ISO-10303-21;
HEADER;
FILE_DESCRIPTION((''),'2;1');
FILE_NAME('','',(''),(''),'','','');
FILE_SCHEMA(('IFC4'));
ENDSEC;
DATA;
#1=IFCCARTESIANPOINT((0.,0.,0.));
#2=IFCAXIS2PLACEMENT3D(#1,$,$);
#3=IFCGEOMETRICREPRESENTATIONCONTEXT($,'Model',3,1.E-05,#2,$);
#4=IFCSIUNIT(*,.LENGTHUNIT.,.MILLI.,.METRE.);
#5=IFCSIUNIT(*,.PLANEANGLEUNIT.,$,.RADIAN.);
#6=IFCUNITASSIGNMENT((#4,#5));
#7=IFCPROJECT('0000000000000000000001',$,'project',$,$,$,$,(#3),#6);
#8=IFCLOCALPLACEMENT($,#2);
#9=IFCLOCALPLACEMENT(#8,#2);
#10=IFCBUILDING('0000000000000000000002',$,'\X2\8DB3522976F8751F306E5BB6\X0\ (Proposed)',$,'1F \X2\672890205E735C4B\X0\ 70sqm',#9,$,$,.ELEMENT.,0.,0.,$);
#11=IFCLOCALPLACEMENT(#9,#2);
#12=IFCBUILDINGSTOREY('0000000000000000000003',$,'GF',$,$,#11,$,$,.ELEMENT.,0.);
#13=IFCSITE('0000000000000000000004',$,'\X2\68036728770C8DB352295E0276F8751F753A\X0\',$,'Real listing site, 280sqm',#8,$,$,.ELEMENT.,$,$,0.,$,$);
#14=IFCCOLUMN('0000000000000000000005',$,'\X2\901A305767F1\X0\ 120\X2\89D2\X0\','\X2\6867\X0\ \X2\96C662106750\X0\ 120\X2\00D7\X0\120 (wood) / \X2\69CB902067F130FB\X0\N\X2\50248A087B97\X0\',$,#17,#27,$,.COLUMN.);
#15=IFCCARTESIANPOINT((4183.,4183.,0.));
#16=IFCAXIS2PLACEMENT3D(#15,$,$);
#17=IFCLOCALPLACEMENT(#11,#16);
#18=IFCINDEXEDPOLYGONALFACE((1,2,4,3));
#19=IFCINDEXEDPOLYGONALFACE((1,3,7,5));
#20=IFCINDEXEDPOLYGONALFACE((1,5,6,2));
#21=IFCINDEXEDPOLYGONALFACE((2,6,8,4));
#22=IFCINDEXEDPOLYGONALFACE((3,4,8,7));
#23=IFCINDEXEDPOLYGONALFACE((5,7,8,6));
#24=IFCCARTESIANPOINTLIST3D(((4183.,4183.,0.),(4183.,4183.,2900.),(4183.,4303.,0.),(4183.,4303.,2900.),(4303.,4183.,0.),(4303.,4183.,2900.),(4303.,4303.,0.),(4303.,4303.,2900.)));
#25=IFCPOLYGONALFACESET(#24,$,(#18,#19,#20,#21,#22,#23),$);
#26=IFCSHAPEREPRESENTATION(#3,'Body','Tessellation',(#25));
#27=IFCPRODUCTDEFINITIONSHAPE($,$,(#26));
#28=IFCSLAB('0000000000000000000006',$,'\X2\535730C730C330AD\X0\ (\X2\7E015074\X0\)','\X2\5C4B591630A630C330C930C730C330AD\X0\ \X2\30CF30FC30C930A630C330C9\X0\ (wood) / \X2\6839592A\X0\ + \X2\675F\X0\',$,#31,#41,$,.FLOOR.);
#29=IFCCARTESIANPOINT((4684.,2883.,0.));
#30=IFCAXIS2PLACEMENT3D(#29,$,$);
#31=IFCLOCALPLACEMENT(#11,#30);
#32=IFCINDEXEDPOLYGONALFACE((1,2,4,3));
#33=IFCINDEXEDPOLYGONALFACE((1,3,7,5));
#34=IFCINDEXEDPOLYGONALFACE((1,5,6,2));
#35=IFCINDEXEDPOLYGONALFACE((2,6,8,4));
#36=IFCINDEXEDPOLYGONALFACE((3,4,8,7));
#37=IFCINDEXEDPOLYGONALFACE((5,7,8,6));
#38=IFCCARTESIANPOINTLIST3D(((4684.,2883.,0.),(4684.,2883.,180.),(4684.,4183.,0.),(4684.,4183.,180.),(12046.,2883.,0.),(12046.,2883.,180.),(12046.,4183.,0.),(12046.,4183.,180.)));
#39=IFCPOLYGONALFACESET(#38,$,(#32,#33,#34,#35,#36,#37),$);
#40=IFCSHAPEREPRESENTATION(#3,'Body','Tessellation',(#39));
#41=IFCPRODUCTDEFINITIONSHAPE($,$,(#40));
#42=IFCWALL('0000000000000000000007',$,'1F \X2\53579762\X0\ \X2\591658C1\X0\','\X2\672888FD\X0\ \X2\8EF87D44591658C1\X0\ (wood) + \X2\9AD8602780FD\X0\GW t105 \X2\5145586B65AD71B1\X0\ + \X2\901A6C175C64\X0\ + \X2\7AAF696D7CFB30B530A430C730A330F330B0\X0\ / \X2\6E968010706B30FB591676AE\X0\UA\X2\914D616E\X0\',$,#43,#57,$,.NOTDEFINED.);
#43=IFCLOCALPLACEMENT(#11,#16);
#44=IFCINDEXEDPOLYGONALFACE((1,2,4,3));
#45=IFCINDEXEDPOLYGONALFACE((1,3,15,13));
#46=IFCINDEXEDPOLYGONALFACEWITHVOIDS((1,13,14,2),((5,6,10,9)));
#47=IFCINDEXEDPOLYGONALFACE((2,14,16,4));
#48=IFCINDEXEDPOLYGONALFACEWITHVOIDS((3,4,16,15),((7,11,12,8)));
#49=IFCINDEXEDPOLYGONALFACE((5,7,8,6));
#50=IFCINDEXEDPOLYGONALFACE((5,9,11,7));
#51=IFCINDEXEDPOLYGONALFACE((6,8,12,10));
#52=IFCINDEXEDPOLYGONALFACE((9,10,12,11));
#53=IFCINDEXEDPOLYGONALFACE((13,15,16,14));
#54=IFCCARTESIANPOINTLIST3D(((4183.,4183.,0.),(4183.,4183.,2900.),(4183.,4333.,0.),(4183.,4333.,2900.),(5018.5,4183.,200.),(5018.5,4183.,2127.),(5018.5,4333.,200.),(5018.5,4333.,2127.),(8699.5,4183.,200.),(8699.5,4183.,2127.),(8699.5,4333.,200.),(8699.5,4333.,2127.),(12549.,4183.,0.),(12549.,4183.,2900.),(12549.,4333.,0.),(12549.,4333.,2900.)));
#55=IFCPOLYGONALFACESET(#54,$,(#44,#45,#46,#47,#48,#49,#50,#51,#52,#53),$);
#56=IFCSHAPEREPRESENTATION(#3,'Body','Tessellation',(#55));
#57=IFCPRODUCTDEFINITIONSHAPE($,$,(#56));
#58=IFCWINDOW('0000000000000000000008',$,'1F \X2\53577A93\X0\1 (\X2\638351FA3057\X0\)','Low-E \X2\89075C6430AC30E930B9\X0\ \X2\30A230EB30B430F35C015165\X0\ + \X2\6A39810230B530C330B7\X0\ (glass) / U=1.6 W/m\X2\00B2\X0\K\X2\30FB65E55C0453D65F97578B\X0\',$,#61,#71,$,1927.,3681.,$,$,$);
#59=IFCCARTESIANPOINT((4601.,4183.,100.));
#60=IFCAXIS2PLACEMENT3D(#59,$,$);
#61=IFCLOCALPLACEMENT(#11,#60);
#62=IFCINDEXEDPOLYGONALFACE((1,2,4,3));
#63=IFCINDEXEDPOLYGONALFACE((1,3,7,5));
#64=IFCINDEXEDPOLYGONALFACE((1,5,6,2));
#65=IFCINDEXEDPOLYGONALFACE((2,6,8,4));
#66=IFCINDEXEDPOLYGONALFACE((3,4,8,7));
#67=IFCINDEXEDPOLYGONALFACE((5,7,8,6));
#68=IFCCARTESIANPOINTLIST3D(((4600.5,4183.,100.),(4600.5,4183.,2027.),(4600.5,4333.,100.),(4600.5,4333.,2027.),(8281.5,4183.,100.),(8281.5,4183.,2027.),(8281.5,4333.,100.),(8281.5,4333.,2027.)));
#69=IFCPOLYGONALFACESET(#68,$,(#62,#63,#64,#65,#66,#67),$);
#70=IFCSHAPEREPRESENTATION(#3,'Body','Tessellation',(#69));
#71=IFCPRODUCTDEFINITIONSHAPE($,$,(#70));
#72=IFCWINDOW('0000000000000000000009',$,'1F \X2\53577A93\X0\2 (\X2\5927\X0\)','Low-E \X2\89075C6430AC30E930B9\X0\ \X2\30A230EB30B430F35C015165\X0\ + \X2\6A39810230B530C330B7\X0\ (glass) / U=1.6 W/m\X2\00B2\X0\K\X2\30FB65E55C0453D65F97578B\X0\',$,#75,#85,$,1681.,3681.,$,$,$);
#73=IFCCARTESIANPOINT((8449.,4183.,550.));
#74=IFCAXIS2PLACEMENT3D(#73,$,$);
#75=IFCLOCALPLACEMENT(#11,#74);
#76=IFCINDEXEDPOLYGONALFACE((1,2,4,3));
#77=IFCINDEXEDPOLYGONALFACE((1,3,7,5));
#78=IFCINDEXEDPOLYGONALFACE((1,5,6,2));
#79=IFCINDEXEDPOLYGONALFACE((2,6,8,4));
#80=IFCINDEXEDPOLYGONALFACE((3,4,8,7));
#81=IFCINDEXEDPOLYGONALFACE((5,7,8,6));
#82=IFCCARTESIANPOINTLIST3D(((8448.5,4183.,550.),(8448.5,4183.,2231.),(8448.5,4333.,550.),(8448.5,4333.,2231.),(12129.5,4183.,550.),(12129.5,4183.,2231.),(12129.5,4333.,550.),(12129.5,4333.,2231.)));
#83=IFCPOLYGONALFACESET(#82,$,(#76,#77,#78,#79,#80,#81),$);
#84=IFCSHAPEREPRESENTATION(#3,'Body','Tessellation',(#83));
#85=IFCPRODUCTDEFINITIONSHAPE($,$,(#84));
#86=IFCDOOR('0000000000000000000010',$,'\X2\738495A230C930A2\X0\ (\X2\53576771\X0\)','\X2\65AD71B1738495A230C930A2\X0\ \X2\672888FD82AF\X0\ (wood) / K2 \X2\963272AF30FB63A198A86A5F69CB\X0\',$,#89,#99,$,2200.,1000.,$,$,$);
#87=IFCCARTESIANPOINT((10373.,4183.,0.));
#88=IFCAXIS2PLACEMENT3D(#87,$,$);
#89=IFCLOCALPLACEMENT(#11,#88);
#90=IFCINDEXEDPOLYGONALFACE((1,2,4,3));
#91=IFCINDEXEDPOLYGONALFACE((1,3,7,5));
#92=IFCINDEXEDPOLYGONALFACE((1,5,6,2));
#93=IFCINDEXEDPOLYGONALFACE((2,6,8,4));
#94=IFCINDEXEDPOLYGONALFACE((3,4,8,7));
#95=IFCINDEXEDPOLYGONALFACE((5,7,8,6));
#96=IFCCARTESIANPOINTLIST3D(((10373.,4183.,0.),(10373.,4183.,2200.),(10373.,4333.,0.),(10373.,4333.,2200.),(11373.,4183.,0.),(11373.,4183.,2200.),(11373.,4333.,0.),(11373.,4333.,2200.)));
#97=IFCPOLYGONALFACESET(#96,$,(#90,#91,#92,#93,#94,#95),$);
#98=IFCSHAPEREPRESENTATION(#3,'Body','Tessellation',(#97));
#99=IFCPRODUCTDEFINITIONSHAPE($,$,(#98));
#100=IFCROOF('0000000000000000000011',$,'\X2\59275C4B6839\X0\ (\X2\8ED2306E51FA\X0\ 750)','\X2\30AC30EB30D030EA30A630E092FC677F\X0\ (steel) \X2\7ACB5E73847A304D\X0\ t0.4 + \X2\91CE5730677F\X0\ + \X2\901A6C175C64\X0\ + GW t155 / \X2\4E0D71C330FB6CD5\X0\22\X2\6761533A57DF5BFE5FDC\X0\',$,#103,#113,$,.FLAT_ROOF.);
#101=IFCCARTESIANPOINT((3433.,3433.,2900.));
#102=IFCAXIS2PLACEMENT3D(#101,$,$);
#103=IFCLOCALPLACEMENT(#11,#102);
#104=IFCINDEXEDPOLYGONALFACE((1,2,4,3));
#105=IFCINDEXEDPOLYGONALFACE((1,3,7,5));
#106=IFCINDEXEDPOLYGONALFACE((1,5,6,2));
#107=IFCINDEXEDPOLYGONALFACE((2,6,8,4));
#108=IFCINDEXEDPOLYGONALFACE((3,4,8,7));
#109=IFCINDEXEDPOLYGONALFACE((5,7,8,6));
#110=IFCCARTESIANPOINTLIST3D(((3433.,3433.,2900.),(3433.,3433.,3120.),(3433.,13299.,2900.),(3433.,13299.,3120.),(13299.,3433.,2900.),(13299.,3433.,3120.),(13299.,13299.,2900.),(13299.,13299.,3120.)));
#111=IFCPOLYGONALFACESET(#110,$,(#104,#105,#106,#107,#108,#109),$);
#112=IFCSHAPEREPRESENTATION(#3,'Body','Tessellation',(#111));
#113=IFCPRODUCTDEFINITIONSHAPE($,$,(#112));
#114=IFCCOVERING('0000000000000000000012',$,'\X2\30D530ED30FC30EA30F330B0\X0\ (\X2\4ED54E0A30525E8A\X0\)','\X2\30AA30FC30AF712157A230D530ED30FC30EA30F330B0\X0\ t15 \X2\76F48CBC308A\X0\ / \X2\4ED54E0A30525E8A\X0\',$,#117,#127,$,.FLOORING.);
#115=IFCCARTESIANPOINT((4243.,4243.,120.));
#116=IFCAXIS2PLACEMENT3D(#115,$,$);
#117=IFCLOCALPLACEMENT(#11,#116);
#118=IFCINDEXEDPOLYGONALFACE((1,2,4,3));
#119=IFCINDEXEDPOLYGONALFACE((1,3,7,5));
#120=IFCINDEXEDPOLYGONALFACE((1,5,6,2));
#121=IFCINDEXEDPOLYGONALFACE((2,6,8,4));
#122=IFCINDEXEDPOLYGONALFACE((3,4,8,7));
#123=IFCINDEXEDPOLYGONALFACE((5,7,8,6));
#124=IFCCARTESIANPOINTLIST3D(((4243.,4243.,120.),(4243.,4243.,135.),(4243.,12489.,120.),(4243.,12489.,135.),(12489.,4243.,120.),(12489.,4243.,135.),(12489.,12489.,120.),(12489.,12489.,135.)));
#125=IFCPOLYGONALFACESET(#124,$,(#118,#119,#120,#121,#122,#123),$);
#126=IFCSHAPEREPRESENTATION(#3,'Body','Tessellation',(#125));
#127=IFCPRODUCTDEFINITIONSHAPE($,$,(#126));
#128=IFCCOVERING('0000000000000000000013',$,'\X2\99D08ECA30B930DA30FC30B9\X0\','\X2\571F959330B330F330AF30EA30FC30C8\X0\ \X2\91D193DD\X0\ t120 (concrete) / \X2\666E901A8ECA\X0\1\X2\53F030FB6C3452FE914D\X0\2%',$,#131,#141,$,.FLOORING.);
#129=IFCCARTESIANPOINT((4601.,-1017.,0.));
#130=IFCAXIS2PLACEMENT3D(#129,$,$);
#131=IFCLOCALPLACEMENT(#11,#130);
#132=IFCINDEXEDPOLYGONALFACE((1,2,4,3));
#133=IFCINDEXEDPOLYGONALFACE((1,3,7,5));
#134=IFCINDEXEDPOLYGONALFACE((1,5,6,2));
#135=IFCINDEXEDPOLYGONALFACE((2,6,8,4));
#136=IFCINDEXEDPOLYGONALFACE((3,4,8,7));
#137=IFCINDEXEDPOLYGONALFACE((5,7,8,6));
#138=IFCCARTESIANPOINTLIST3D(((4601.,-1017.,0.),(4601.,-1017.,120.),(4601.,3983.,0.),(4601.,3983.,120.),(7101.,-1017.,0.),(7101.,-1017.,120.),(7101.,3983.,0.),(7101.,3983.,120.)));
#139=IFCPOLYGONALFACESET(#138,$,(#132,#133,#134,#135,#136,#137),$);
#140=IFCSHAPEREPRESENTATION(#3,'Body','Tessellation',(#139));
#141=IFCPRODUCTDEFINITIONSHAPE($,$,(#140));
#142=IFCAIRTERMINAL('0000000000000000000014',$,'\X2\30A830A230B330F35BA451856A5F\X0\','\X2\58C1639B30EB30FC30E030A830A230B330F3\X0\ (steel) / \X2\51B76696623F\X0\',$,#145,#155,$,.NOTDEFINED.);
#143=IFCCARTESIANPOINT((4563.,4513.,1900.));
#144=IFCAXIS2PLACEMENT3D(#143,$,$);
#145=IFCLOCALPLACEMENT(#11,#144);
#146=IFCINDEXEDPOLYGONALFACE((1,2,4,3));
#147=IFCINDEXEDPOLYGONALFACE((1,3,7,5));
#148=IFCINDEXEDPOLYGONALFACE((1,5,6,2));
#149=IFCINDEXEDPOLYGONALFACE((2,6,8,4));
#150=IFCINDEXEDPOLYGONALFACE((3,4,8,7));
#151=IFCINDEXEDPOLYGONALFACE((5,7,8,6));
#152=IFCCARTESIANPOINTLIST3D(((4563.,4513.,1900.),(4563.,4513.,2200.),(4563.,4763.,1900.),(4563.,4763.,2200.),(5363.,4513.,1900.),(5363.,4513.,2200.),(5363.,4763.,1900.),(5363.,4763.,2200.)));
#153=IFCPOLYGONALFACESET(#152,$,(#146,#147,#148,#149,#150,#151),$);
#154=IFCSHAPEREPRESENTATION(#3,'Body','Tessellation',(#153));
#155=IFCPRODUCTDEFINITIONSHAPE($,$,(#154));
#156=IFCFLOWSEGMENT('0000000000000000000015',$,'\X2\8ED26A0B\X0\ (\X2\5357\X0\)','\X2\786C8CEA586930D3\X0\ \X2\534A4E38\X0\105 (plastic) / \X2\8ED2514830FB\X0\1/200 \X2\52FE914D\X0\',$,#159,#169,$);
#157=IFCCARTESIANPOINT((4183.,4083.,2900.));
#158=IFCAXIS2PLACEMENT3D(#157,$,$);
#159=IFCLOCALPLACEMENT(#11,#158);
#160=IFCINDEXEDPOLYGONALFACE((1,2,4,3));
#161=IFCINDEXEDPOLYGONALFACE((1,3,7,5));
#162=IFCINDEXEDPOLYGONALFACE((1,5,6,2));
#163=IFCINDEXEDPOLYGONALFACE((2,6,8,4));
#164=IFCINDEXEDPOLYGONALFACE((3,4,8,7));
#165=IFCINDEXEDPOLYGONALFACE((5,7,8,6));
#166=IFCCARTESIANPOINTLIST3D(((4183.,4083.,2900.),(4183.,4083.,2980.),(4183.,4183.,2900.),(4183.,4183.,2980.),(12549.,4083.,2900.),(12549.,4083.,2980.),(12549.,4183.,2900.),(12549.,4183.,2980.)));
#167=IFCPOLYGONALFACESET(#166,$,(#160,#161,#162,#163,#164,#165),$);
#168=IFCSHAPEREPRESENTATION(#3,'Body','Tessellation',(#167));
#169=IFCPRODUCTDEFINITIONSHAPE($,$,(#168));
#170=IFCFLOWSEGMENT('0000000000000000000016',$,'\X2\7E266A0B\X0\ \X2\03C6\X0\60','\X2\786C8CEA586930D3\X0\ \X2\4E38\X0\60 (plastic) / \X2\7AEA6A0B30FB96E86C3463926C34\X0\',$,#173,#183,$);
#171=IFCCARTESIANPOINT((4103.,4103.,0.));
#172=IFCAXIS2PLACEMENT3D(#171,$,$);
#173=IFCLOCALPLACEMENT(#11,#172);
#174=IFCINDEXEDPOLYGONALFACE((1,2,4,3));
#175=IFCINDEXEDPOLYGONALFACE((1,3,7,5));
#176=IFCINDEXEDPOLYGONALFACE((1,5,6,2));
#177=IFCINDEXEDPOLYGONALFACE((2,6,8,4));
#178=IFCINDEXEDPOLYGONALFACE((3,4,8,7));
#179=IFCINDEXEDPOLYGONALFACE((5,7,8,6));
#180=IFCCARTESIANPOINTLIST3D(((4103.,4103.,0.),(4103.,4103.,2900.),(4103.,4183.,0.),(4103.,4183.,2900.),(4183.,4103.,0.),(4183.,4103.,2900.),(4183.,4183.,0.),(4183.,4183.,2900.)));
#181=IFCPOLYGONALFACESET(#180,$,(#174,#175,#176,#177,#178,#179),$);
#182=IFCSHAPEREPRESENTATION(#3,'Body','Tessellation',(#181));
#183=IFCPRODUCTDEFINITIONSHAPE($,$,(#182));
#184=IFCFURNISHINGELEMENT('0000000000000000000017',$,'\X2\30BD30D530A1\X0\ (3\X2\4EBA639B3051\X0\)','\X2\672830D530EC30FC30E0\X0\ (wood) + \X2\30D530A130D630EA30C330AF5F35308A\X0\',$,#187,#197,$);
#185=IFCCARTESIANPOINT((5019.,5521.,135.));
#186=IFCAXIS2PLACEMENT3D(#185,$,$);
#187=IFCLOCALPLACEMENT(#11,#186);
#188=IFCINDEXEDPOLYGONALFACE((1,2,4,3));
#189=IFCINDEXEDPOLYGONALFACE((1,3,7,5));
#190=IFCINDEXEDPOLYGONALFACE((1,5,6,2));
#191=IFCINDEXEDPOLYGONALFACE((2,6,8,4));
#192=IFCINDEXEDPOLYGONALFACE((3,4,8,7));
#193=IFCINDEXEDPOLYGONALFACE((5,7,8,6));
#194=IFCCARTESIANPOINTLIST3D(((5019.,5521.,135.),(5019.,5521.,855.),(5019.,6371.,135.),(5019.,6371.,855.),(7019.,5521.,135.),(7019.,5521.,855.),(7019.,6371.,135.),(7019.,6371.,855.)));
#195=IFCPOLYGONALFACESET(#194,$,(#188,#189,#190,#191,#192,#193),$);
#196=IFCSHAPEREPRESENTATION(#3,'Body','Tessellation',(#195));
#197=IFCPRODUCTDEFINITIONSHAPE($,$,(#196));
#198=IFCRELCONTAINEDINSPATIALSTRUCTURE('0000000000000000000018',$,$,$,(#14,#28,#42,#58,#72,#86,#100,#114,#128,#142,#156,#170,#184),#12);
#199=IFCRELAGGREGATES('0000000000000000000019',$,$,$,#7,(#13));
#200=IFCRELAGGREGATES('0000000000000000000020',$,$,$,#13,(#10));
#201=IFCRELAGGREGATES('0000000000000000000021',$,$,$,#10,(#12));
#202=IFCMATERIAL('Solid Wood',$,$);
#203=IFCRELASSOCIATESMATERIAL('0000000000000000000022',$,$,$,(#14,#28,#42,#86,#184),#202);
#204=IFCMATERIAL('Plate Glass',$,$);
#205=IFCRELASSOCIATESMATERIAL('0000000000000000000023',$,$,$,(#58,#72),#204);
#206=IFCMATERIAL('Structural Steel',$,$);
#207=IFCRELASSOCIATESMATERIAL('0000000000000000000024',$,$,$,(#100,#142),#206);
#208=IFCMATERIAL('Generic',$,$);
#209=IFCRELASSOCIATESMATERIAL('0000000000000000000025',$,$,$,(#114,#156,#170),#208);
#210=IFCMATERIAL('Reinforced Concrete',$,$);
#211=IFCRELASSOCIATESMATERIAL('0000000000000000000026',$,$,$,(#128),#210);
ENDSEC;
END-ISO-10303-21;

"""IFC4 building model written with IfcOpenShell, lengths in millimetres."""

from ifc_helpers import new_model, si_unit, frame, frame_2d, origin, place, context, project, spatial, rectangle, extrude, material, element, fill, save


model = new_model("IFC4")

# Units and contexts
model_context = context("Model", 3, precision=1e-05, world=origin())
ifc_project = project(units=[si_unit("LENGTHUNIT", "METRE", prefix="MILLI"), si_unit("PLANEANGLEUNIT", "RADIAN")], contexts=[model_context])

# Site, building, storey
site_placement = place(None, origin())
site = spatial("IfcSite", under=ifc_project, at=site_placement, Name="栃木県足利市相生町", ObjectType="Real listing site, 280sqm", CompositionType="ELEMENT", RefElevation=0.0)
building_placement = place(site_placement, origin())
building = spatial("IfcBuilding", under=site, at=building_placement, Name="足利相生の家 (Proposed)", ObjectType="1F 木造平屋 70sqm", CompositionType="ELEMENT", ElevationOfRefHeight=0.0, ElevationOfTerrain=0.0)
storey_placement = place(building_placement, origin())
storey = spatial("IfcBuildingStorey", under=building, at=storey_placement, Name="GF", CompositionType="ELEMENT", Elevation=0.0)

# Column
ifc_material_1 = material(Name="Solid Wood")
column_1_placement = place(storey_placement, frame((4183.0, 4183.0, 0.0)))
element("IfcColumn", 1, at=column_1_placement, inside=storey, material=ifc_material_1, Name="通し柱 120角", Description="桧 集成材 120×120 (wood) / 構造柱・N値計算", PredefinedType="COLUMN", context=model_context, shape_type="SweptSolid", body=[
    extrude(rectangle(XDim=120.0, YDim=120.0, at=frame_2d((60.0, 60.0))), frame((4183.0, 4183.0, 0.0)), (0.0, 0.0, 1.0), 2900.0),
])

# Slab
ifc_material_2 = material(Name="Reinforced Concrete")
slab_1_placement = place(storey_placement, frame((4684.0, 2883.0, 0.0)))
element("IfcSlab", 2, at=slab_1_placement, inside=storey, material=ifc_material_1, Name="南デッキ (縁側)", Description="屋外ウッドデッキ ハードウッド (wood) / 根太 + 束", PredefinedType="FLOOR", context=model_context, shape_type="SweptSolid", body=[
    extrude(rectangle(XDim=7362.0, YDim=1300.0, at=frame_2d((3681.0, 650.0))), frame((4684.0, 2883.0, 0.0)), (0.0, 0.0, 1.0), 180.0),
])

# Wall, openings, windows, door
wall_1_placement = place(storey_placement, frame((4183.0, 4183.0, 0.0)))
wall_1 = element("IfcWall", 3, at=wall_1_placement, inside=storey, material=ifc_material_1, Name="1F 南面 外壁", Description="木製 軸組外壁 (wood) + 高性能GW t105 充填断熱 + 通気層 + 窯業系サイディング / 準耐火・外皮UA配慮", PredefinedType="NOTDEFINED", context=model_context, shape_type="SweptSolid", body=[
    extrude(rectangle(XDim=8366.0, YDim=150.0, at=frame_2d((4183.0, 75.0))), frame((4183.0, 4183.0, 0.0)), (0.0, 0.0, 1.0), 2900.0),
])
opening_1_placement = place(storey_placement, frame((4601.0, 4183.0, 100.0)))
opening_1 = element("IfcOpeningElement", 4, at=opening_1_placement, cuts=wall_1, PredefinedType="NOTDEFINED", context=model_context, shape_type="SweptSolid", body=[
    extrude(rectangle(XDim=3681.0, YDim=150.0, at=frame_2d((1840.0, 75.0))), frame((4601.0, 4183.0, 100.0)), (0.0, 0.0, 1.0), 1927.0),
])
opening_2_placement = place(storey_placement, frame((8449.0, 4183.0, 550.0)))
opening_2 = element("IfcOpeningElement", 5, at=opening_2_placement, cuts=wall_1, PredefinedType="NOTDEFINED", context=model_context, shape_type="SweptSolid", body=[
    extrude(rectangle(XDim=3681.0, YDim=150.0, at=frame_2d((1840.0, 75.0))), frame((8449.0, 4183.0, 550.0)), (0.0, 0.0, 1.0), 1681.0),
])
opening_3_placement = place(storey_placement, frame((10373.0, 4183.0, 0.0)))
opening_3 = element("IfcOpeningElement", 6, at=opening_3_placement, cuts=wall_1, PredefinedType="NOTDEFINED", context=model_context, shape_type="SweptSolid", body=[
    extrude(rectangle(XDim=1000.0, YDim=150.0, at=frame_2d((500.0, 75.0))), frame((10373.0, 4183.0, 0.0)), (0.0, 0.0, 1.0), 2200.0),
])
ifc_material_3 = material(Name="Plate Glass")
window_1_placement = place(storey_placement, frame((4601.0, 4183.0, 100.0)))
window_1 = element("IfcWindow", 7, at=window_1_placement, inside=storey, material=ifc_material_3, Name="1F 南窓1 (掃出し)", Description="Low-E 複層ガラス アルゴン封入 + 樹脂サッシ (glass) / U=1.6 W/m²K・日射取得型", OverallHeight=1927.0, OverallWidth=3681.0, context=model_context, shape_type="SweptSolid", body=[
    extrude(rectangle(XDim=3681.0, YDim=150.0, at=frame_2d((1840.0, 75.0))), frame((4601.0, 4183.0, 100.0)), (0.0, 0.0, 1.0), 1927.0),
])
fill(opening_1, window_1)
window_2_placement = place(storey_placement, frame((8449.0, 4183.0, 550.0)))
window_2 = element("IfcWindow", 8, at=window_2_placement, inside=storey, material=ifc_material_3, Name="1F 南窓2 (大)", Description="Low-E 複層ガラス アルゴン封入 + 樹脂サッシ (glass) / U=1.6 W/m²K・日射取得型", OverallHeight=1681.0, OverallWidth=3681.0, context=model_context, shape_type="SweptSolid", body=[
    extrude(rectangle(XDim=3681.0, YDim=150.0, at=frame_2d((1840.0, 75.0))), frame((8449.0, 4183.0, 550.0)), (0.0, 0.0, 1.0), 1681.0),
])
fill(opening_2, window_2)
door_placement = place(storey_placement, frame((10373.0, 4183.0, 0.0)))
door = element("IfcDoor", 9, at=door_placement, inside=storey, material=ifc_material_1, Name="玄関ドア (南東)", Description="断熱玄関ドア 木製芯 (wood) / K2 防犯・採風機構", OverallHeight=2200.0, OverallWidth=1000.0, context=model_context, shape_type="SweptSolid", body=[
    extrude(rectangle(XDim=1000.0, YDim=150.0, at=frame_2d((500.0, 75.0))), frame((10373.0, 4183.0, 0.0)), (0.0, 0.0, 1.0), 2200.0),
])
fill(opening_3, door)

# Roof
ifc_material_4 = material(Name="Structural Steel")
roof_placement = place(storey_placement, frame((3433.0, 3433.0, 2900.0)))
element("IfcRoof", 10, at=roof_placement, inside=storey, material=ifc_material_4, Name="大屋根 (軒の出 750)", Description="ガルバリウム鋼板 (steel) 立平葺き t0.4 + 野地板 + 通気層 + GW t155 / 不燃・法22条区域対応", PredefinedType="FLAT_ROOF", context=model_context, shape_type="SweptSolid", body=[
    extrude(rectangle(XDim=9866.0, YDim=9866.0, at=frame_2d((4933.0, 4933.0))), frame((3433.0, 3433.0, 2900.0)), (0.0, 0.0, 1.0), 220.0),
])

# Coverings
ifc_material_5 = material(Name="Generic")
covering_1_placement = place(storey_placement, frame((4243.0, 4243.0, 120.0)))
element("IfcCovering", 11, at=covering_1_placement, inside=storey, material=ifc_material_5, Name="フローリング (仕上げ床)", Description="オーク無垢フローリング t15 直貼り / 仕上げ床", PredefinedType="FLOORING", context=model_context, shape_type="SweptSolid", body=[
    extrude(rectangle(XDim=8246.0, YDim=8246.0, at=frame_2d((4123.0, 4123.0))), frame((4243.0, 4243.0, 120.0)), (0.0, 0.0, 1.0), 15.0),
])
covering_2_placement = place(storey_placement, frame((4601.0, -1017.0, 0.0)))
element("IfcCovering", 12, at=covering_2_placement, inside=storey, material=ifc_material_2, Name="駐車スペース", Description="土間コンクリート 金鏝 t120 (concrete) / 普通車1台・水勾配2%", PredefinedType="FLOORING", context=model_context, shape_type="SweptSolid", body=[
    extrude(rectangle(XDim=2500.0, YDim=5000.0, at=frame_2d((1250.0, 2500.0))), frame((4601.0, -1017.0, 0.0)), (0.0, 0.0, 1.0), 120.0),
])

# Air terminal
air_terminal_placement = place(storey_placement, frame((4563.0, 4513.0, 1900.0)))
element("IfcAirTerminal", 13, at=air_terminal_placement, inside=storey, material=ifc_material_4, Name="エアコン室内機", Description="壁掛ルームエアコン (steel) / 冷暖房", PredefinedType="NOTDEFINED", context=model_context, shape_type="SweptSolid", body=[
    extrude(rectangle(XDim=800.0, YDim=250.0, at=frame_2d((400.0, 125.0))), frame((4563.0, 4513.0, 1900.0)), (0.0, 0.0, 1.0), 300.0),
])

# Flow segments
flow_segment_1_placement = place(storey_placement, frame((4183.0, 4083.0, 2900.0)))
element("IfcFlowSegment", 14, at=flow_segment_1_placement, inside=storey, material=ifc_material_5, Name="軒樋 (南)", Description="硬質塩ビ 半丸105 (plastic) / 軒先・1/200 勾配", context=model_context, shape_type="SweptSolid", body=[
    extrude(rectangle(XDim=8366.0, YDim=100.0, at=frame_2d((4183.0, 50.0))), frame((4183.0, 4083.0, 2900.0)), (0.0, 0.0, 1.0), 80.0),
])
flow_segment_2_placement = place(storey_placement, frame((4103.0, 4103.0, 0.0)))
element("IfcFlowSegment", 15, at=flow_segment_2_placement, inside=storey, material=ifc_material_5, Name="縦樋 φ60", Description="硬質塩ビ 丸60 (plastic) / 竪樋・雨水排水", context=model_context, shape_type="SweptSolid", body=[
    extrude(rectangle(XDim=80.0, YDim=80.0, at=frame_2d((40.0, 40.0))), frame((4103.0, 4103.0, 0.0)), (0.0, 0.0, 1.0), 2900.0),
])

# Furnishing element
furnishing_1_placement = place(storey_placement, frame((5019.0, 5521.0, 135.0)))
element("IfcFurnishingElement", 16, at=furnishing_1_placement, inside=storey, material=ifc_material_1, Name="ソファ (3人掛け)", Description="木フレーム (wood) + ファブリック張り", context=model_context, shape_type="SweptSolid", body=[
    extrude(rectangle(XDim=2000.0, YDim=850.0, at=frame_2d((1000.0, 425.0))), frame((5019.0, 5521.0, 135.0)), (0.0, 0.0, 1.0), 720.0),
])

save(model, "model.ifc")
